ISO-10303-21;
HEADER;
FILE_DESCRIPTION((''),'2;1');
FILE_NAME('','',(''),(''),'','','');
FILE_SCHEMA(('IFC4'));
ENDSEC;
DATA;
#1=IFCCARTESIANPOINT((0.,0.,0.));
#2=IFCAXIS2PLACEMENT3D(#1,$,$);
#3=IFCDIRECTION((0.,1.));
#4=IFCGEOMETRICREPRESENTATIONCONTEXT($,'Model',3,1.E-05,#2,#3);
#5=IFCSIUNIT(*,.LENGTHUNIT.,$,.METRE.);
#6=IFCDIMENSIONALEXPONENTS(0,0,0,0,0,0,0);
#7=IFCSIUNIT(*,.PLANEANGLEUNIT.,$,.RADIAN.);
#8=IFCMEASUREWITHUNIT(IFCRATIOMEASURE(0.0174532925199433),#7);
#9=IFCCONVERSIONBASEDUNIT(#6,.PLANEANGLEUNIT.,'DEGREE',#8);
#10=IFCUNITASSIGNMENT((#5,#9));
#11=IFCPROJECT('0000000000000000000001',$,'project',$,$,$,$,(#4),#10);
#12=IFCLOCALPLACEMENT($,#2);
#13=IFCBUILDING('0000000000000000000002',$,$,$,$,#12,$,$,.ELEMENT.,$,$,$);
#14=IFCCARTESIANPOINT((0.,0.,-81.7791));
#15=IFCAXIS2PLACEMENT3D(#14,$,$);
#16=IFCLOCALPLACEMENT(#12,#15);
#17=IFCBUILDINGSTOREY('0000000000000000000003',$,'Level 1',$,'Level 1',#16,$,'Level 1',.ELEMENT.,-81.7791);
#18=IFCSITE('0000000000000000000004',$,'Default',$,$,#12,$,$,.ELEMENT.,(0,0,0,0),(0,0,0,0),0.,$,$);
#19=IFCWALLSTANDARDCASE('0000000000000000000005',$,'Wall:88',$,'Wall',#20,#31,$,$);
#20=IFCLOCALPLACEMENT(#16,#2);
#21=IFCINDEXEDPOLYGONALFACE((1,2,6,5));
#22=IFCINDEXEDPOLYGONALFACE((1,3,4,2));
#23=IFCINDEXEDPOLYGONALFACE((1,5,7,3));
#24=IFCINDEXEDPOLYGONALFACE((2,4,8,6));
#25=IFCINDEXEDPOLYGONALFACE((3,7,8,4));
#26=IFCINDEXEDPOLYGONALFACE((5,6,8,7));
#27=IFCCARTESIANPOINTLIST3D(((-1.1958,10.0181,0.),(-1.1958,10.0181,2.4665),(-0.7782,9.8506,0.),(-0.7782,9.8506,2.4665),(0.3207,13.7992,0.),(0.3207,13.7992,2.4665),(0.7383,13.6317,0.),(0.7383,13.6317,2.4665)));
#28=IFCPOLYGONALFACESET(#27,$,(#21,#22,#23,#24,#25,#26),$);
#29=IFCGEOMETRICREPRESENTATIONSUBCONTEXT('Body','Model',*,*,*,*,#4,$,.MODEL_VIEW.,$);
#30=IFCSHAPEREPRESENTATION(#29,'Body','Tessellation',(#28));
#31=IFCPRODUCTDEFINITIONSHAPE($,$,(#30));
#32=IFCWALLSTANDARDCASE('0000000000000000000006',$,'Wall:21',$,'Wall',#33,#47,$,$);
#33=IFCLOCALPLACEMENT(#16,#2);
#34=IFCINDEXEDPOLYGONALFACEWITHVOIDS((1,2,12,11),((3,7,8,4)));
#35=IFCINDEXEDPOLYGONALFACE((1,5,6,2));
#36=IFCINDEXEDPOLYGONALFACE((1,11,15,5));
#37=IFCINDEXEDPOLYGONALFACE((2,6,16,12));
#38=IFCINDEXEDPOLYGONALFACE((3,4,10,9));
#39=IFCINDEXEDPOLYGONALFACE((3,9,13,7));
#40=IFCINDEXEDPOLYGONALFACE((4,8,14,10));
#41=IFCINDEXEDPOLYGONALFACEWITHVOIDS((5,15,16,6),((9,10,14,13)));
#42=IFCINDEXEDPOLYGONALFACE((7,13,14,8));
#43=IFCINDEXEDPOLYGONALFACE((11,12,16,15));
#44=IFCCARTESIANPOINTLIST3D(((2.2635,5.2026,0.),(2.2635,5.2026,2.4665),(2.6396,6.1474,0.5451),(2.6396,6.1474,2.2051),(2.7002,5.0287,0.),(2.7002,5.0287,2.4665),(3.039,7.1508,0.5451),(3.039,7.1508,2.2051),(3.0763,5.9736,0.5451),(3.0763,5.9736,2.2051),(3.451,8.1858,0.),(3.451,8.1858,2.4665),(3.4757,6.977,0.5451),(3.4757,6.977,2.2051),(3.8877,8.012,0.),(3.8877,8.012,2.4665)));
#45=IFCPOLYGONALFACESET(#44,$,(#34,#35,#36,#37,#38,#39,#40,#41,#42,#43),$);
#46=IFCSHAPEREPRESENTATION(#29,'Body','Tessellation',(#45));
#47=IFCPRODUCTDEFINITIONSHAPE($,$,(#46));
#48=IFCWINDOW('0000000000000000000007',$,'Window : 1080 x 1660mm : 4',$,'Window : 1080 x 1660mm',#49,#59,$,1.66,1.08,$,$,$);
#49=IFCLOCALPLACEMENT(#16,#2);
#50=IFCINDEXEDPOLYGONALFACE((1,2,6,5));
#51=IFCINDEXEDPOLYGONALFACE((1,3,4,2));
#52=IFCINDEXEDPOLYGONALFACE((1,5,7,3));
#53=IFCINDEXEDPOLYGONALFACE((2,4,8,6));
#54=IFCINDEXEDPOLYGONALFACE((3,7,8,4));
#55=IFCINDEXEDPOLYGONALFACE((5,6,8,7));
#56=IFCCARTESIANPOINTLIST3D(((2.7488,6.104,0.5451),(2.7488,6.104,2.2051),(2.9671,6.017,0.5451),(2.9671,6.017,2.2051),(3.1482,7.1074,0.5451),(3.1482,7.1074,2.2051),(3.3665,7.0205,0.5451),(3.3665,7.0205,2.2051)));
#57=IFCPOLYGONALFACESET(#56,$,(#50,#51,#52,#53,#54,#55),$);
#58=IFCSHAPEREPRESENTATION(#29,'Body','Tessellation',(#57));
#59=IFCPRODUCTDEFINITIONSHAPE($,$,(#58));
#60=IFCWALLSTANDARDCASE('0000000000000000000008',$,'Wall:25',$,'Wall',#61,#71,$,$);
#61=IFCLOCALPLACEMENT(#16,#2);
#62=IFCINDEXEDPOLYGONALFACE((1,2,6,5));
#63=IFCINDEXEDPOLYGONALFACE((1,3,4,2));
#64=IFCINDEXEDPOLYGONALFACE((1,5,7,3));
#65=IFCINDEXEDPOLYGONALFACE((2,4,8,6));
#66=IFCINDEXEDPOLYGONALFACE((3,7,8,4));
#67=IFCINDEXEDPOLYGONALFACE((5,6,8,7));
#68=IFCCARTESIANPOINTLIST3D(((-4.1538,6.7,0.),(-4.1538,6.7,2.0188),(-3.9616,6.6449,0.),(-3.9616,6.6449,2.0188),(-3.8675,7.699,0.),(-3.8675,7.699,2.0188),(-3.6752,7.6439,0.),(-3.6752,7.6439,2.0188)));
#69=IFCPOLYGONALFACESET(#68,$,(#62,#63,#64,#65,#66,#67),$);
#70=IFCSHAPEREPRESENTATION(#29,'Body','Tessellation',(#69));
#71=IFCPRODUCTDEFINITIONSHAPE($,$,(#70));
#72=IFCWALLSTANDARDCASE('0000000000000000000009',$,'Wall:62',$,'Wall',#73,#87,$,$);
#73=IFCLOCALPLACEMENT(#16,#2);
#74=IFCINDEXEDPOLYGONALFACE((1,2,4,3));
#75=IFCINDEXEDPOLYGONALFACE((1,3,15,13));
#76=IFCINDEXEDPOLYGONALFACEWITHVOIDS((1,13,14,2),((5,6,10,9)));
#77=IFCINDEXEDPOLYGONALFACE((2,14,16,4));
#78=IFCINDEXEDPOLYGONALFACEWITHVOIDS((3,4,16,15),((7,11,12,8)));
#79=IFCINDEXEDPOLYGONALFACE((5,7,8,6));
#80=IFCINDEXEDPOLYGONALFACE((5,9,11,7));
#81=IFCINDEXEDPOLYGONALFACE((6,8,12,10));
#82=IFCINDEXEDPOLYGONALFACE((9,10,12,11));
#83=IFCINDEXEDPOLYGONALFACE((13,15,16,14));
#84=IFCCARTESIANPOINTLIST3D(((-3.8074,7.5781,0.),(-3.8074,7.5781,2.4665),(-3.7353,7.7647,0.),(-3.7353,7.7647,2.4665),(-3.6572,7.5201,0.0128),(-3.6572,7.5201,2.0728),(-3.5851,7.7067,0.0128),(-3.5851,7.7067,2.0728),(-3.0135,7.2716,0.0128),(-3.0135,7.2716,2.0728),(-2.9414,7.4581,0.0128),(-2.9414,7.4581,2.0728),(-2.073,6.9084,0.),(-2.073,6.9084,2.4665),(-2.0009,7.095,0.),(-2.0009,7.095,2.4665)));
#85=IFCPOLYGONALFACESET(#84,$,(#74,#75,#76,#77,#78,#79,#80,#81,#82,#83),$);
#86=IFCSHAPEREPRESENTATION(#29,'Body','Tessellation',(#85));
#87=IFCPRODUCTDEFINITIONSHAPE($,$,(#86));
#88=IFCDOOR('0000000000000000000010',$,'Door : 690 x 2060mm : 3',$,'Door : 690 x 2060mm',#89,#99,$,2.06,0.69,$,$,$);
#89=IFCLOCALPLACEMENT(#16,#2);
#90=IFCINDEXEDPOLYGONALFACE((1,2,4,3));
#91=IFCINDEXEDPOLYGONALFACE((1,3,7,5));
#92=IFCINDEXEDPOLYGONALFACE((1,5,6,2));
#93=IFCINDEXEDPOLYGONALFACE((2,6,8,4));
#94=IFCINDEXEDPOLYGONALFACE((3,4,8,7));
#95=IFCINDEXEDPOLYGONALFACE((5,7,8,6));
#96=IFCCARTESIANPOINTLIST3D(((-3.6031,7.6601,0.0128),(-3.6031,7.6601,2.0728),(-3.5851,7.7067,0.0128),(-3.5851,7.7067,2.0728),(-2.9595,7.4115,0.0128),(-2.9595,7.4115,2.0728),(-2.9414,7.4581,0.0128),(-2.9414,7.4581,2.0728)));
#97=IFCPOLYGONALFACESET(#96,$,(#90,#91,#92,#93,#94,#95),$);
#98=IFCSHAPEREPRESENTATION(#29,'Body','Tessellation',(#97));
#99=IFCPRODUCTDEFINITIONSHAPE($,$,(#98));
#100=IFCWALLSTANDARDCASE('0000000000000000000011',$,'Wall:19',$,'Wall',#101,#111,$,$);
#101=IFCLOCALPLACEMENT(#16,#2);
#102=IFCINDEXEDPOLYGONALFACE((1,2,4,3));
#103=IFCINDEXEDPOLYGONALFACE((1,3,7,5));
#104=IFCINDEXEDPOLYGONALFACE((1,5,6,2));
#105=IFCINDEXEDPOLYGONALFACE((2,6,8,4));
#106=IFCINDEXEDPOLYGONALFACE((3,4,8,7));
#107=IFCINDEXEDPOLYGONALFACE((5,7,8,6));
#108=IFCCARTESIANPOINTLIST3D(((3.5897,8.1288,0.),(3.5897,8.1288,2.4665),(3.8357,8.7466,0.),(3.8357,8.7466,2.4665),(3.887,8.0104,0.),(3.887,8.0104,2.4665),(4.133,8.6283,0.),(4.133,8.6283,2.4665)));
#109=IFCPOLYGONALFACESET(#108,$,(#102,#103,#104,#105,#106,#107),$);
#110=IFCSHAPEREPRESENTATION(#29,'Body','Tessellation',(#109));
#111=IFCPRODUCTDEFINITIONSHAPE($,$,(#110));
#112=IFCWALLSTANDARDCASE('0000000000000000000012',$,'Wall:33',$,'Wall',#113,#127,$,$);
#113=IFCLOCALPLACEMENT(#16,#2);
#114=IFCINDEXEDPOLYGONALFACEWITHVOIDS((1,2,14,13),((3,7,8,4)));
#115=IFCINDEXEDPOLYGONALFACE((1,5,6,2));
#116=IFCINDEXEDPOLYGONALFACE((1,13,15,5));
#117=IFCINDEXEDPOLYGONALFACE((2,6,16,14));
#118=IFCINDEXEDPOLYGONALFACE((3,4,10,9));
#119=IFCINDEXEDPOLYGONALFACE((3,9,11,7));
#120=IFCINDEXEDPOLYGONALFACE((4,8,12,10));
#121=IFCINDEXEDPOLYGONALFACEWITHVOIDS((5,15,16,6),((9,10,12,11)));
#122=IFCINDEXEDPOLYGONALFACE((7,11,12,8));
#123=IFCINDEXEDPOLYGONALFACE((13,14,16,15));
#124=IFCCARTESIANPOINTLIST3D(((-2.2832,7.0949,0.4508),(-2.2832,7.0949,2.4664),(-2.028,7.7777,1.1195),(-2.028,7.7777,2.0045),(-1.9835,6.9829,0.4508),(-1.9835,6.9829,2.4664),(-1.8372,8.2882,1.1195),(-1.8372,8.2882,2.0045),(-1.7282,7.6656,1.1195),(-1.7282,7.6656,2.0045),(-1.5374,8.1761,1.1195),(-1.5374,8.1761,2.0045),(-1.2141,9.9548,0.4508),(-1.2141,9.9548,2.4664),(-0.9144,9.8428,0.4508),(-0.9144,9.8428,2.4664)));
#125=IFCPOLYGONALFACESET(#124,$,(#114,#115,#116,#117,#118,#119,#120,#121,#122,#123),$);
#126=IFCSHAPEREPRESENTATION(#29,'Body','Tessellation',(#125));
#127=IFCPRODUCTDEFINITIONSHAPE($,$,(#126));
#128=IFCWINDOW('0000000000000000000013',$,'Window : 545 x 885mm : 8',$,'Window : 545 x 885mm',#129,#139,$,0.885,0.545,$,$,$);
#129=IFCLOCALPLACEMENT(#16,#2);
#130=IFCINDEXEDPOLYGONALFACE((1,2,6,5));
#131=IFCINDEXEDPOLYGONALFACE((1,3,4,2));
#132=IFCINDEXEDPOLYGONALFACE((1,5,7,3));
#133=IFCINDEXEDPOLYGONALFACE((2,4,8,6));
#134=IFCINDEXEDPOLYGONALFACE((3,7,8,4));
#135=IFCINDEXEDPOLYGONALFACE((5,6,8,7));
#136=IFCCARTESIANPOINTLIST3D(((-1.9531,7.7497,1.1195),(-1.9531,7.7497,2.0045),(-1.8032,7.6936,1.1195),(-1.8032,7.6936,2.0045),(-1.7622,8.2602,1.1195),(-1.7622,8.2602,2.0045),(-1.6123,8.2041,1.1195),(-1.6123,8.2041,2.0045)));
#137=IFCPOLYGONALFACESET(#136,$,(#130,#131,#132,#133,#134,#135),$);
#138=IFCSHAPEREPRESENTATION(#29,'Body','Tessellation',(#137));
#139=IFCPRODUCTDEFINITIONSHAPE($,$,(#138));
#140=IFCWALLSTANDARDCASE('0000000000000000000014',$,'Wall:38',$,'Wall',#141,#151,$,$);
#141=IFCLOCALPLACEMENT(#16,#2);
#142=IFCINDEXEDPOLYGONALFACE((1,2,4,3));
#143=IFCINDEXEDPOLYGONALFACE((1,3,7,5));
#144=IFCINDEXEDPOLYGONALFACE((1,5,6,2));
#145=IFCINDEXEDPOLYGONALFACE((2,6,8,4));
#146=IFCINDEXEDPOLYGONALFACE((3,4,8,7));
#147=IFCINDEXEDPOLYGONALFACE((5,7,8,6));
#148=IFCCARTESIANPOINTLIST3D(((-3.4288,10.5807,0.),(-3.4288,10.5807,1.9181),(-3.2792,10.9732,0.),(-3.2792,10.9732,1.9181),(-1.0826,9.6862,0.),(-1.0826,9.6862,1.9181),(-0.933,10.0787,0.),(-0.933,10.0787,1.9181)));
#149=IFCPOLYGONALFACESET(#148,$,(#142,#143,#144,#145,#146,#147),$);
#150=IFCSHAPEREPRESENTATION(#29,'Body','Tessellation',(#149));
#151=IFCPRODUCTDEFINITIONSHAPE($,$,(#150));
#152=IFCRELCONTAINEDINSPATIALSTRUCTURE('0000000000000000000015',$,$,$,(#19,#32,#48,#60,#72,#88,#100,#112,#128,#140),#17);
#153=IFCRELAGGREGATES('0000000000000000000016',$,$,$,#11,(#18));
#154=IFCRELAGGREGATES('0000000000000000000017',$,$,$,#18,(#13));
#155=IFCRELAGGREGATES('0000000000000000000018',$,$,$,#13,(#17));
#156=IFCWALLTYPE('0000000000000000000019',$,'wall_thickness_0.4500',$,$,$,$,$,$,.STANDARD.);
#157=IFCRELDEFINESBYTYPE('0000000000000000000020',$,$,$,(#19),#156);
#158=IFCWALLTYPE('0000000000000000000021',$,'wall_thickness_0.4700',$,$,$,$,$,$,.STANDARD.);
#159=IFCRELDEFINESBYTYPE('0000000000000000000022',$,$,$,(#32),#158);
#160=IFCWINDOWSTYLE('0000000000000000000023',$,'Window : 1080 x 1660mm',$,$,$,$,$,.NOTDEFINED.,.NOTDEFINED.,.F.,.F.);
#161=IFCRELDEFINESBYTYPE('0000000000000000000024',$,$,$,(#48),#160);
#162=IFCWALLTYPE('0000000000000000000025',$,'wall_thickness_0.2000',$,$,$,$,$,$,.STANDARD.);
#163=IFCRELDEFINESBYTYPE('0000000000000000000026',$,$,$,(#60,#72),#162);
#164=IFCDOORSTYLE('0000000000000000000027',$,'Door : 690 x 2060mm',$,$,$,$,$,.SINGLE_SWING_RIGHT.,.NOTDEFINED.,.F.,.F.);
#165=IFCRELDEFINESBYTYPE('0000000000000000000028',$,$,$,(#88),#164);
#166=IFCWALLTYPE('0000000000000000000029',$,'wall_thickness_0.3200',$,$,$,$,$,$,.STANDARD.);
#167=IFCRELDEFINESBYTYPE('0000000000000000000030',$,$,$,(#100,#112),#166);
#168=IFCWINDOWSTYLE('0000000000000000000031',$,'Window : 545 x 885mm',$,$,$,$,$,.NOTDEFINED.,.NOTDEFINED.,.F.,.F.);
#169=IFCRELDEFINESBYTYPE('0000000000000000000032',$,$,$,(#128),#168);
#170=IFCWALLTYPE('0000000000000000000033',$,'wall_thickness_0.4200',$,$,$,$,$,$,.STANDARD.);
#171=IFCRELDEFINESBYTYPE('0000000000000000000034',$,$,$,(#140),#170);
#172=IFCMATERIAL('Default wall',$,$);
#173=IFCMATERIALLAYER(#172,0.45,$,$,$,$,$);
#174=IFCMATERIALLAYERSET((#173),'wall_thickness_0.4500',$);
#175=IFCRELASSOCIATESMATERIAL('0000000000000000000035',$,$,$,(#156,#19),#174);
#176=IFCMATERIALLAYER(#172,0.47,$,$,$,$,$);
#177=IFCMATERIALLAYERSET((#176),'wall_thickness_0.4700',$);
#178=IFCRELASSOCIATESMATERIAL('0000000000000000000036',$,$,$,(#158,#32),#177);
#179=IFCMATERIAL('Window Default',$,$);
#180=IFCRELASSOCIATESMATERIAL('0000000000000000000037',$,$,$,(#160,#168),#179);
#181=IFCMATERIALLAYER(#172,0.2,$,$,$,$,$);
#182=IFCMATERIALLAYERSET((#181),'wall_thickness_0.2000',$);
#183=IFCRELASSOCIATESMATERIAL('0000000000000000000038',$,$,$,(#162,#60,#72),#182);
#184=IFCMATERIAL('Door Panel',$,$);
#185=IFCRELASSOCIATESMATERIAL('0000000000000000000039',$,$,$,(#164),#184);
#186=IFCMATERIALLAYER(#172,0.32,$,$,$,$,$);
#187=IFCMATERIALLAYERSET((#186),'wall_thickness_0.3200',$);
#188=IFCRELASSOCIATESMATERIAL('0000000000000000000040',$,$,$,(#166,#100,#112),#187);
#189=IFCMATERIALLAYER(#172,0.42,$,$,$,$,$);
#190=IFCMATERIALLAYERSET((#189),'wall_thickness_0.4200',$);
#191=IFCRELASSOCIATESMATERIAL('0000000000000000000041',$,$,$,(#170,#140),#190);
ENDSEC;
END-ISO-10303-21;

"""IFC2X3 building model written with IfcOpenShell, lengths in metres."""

from ifc_helpers import new_model, entity, si_unit, converted_unit, direction, frame, frame_2d, origin, origin_2d_with_axis, place, context, subcontext, project, spatial, polyline, rectangle, outline, extrude, source, transform, mapped, material, layer, layer_set, layer_usage, type_object, type_shapes, element, fill, save


model = new_model("IFC2X3")

# Units and contexts
model_context = context("Model", 3, precision=1e-05, world=origin(), true_north=direction((0.0, 1.0)))
body_context = subcontext(model_context, "Body", "Model", "MODEL_VIEW")
ifc_project = project(units=[si_unit("LENGTHUNIT", "METRE"), converted_unit("PLANEANGLEUNIT", "DEGREE", entity("IfcRatioMeasure", 0.0174532925199433), si_unit("PLANEANGLEUNIT", "RADIAN"), dimensions=[0, 0, 0, 0, 0, 0, 0])], contexts=[model_context])

# Site, building, storey
placement_1 = place(None, origin())
site = spatial("IfcSite", under=ifc_project, at=placement_1, Name="Default", CompositionType="ELEMENT", RefLatitude=(0, 0, 0, 0), RefLongitude=(0, 0, 0, 0), RefElevation=0.0)
building = spatial("IfcBuilding", under=site, at=placement_1, CompositionType="ELEMENT")
storey_placement = place(placement_1, frame((0.0, 0.0, -81.7791)))
storey = spatial("IfcBuildingStorey", under=building, at=storey_placement, Name="Level 1", ObjectType="Level 1", LongName="Level 1", CompositionType="ELEMENT", Elevation=-81.7791)

# Shared definitions
ifc_material_1 = material(Name="Default wall")

# Shared definitions
ifc_material_2 = material(Name="Window Default")

# Wall
ifc_layer_1 = layer(ifc_material_1, 0.45)
ifc_layer_set_1 = layer_set([ifc_layer_1], Name="wall_thickness_0.4500")
ifc_layer_usage_1 = layer_usage(ifc_layer_set_1, "AXIS2", "POSITIVE", -0.225)
wall_type_1 = type_object("IfcWallType", Name="wall_thickness_0.4500", PredefinedType="STANDARD", material=ifc_layer_set_1)
wall_1_placement = place(storey_placement, frame((0.5295, 13.7154, 0.0), z_axis=(0.0, 0.0, 1.0), x_axis=(-0.372256, -0.92813, 0.0)))
element("IfcWallStandardCase", 1, at=wall_1_placement, inside=storey, type_object=wall_type_1, material=ifc_layer_usage_1, Name="Wall:88", ObjectType="Wall", context=body_context, shape_type="SweptSolid", body=[
    extrude(outline(polyline([(4.0739, -0.225), (4.0739, 0.225), (0.0, 0.225), (0.0, -0.225), (4.0739, -0.225)])), origin(), (0.0, 0.0, 1.0), 2.4665),
])

# Wall, opening, window
ifc_layer_2 = layer(ifc_material_1, 0.47)
ifc_layer_set_2 = layer_set([ifc_layer_2], Name="wall_thickness_0.4700")
ifc_layer_usage_2 = layer_usage(ifc_layer_set_2, "AXIS2", "POSITIVE", -0.235)
wall_type_2 = type_object("IfcWallType", Name="wall_thickness_0.4700", PredefinedType="STANDARD", material=ifc_layer_set_2)
wall_2_placement = place(storey_placement, frame((3.6693, 8.0989, 0.0), z_axis=(0.0, 0.0, 1.0), x_axis=(-0.36982, -0.929103, 0.0)))
wall_2 = element("IfcWallStandardCase", 2, at=wall_2_placement, inside=storey, type_object=wall_type_2, material=ifc_layer_usage_2, Name="Wall:21", ObjectType="Wall", context=body_context, shape_type="SweptSolid", body=[
    extrude(outline(polyline([(3.2109, -0.235), (3.2109, 0.235), (0.0, 0.235), (0.0, -0.235), (3.2109, -0.235)])), origin(), (0.0, 0.0, 1.0), 2.4665),
])
opening_1_placement = place(wall_2_placement, frame((1.1139, -0.235, 0.5451)))
opening_1 = element("IfcOpeningElement", 3, at=opening_1_placement, cuts=wall_2, ObjectType="Opening", context=body_context, shape_type="SweptSolid", body=[
    extrude(rectangle(XDim=1.08, YDim=1.66, at=frame_2d((0.83, 0.54), x_axis=(0.0, 1.0))), frame((0.0, 0.0, 0.0), z_axis=(0.0, 1.0, 0.0), x_axis=(0.0, 0.0, 1.0)), (0.0, 0.0, 1.0), 0.47),
])
window_style_1 = type_object("IfcWindowStyle", Name="Window : 1080 x 1660mm", ConstructionType="NOTDEFINED", OperationType="NOTDEFINED", ParameterTakesPrecedence=False, Sizeable=False, material=ifc_material_2)
shared_shape_1 = source(origin(), body_context, "Body", "SweptSolid", [
    extrude(rectangle(XDim=0.235, YDim=1.08, at=origin_2d_with_axis()), frame((0.54, 0.235, 0.0), z_axis=(0.0, 0.0, 1.0), x_axis=(0.0, 1.0, 0.0)), (0.0, 0.0, 1.0), 1.66),
])
type_shapes(window_style_1, [shared_shape_1])
window_1_placement = place(opening_1_placement, origin())
window_1 = element("IfcWindow", 4, at=window_1_placement, inside=storey, type_object=window_style_1, Name="Window : 1080 x 1660mm : 4", ObjectType="Window : 1080 x 1660mm", OverallHeight=1.66, OverallWidth=1.08, context=body_context, shape_type="MappedRepresentation", body=[
    mapped(shared_shape_1, transform((0.0, 0.0, 0.0), scale=1.0)),
])
fill(opening_1, window_1)

# Wall
ifc_layer_3 = layer(ifc_material_1, 0.2)
ifc_layer_set_3 = layer_set([ifc_layer_3], Name="wall_thickness_0.2000")
ifc_layer_usage_3 = layer_usage(ifc_layer_set_3, "AXIS2", "POSITIVE", -0.1)
wall_type_3 = type_object("IfcWallType", Name="wall_thickness_0.2000", PredefinedType="STANDARD", material=ifc_layer_set_3)
wall_3_placement = place(storey_placement, frame((-3.7713, 7.6714, 0.0), z_axis=(0.0, 0.0, 1.0), x_axis=(-0.275571, -0.961281, 0.0)))
element("IfcWallStandardCase", 5, at=wall_3_placement, inside=storey, type_object=wall_type_3, material=ifc_layer_usage_3, Name="Wall:25", ObjectType="Wall", context=body_context, shape_type="SweptSolid", body=[
    extrude(outline(polyline([(1.0392, -0.1), (1.0392, 0.1), (0.0, 0.1), (0.0, -0.1), (1.0392, -0.1)])), origin(), (0.0, 0.0, 1.0), 2.0188),
])

# Wall, opening, door
wall_4_placement = place(storey_placement, frame((-3.7713, 7.6714, 0.0), z_axis=(0.0, 0.0, 1.0), x_axis=(0.932862, -0.360233, 0.0)))
wall_4 = element("IfcWallStandardCase", 6, at=wall_4_placement, inside=storey, type_object=wall_type_3, material=ifc_layer_usage_3, Name="Wall:62", ObjectType="Wall", context=body_context, shape_type="SweptSolid", body=[
    extrude(outline(polyline([(1.8592, -0.1), (1.8592, 0.1), (0.0, 0.1), (0.0, -0.1), (1.8592, -0.1)])), origin(), (0.0, 0.0, 1.0), 2.4665),
])
opening_2_placement = place(wall_4_placement, frame((0.161, -0.1, 0.0128)))
opening_2 = element("IfcOpeningElement", 7, at=opening_2_placement, cuts=wall_4, ObjectType="Opening", context=body_context, shape_type="SweptSolid", body=[
    extrude(rectangle(XDim=0.69, YDim=2.06, at=frame_2d((1.03, 0.345), x_axis=(0.0, 1.0))), frame((0.0, 0.0, 0.0), z_axis=(0.0, 1.0, 0.0), x_axis=(0.0, 0.0, 1.0)), (0.0, 0.0, 1.0), 0.2),
])
ifc_material_3 = material(Name="Door Panel")
door_style_1 = type_object("IfcDoorStyle", Name="Door : 690 x 2060mm", ConstructionType="NOTDEFINED", OperationType="SINGLE_SWING_RIGHT", ParameterTakesPrecedence=False, Sizeable=False, material=ifc_material_3)
shared_shape_2 = source(origin(), body_context, "Body", "SweptSolid", [
    extrude(rectangle(XDim=0.05, YDim=0.69, at=origin_2d_with_axis()), frame((0.345, 0.175, 0.0), z_axis=(0.0, 0.0, 1.0), x_axis=(0.0, 1.0, 0.0)), (0.0, 0.0, 1.0), 2.06),
])
type_shapes(door_style_1, [shared_shape_2])
door_1_placement = place(opening_2_placement, origin())
door_1 = element("IfcDoor", 8, at=door_1_placement, inside=storey, type_object=door_style_1, Name="Door : 690 x 2060mm : 3", ObjectType="Door : 690 x 2060mm", OverallHeight=2.06, OverallWidth=0.69, context=body_context, shape_type="MappedRepresentation", body=[
    mapped(shared_shape_2, transform((0.0, 0.0, 0.0), scale=1.0)),
])
fill(opening_2, door_1)

# Wall
ifc_layer_4 = layer(ifc_material_1, 0.32)
ifc_layer_set_4 = layer_set([ifc_layer_4], Name="wall_thickness_0.3200")
ifc_layer_usage_4 = layer_usage(ifc_layer_set_4, "AXIS2", "POSITIVE", -0.16)
wall_type_4 = type_object("IfcWallType", Name="wall_thickness_0.3200", PredefinedType="STANDARD", material=ifc_layer_set_4)
wall_5_placement = place(storey_placement, frame((3.9843, 8.6874, 0.0), z_axis=(0.0, 0.0, 1.0), x_axis=(-0.369819, -0.929104, 0.0)))
element("IfcWallStandardCase", 9, at=wall_5_placement, inside=storey, type_object=wall_type_4, material=ifc_layer_usage_4, Name="Wall:19", ObjectType="Wall", context=body_context, shape_type="SweptSolid", body=[
    extrude(outline(polyline([(0.665, -0.16), (0.665, 0.16), (0.0, 0.16), (0.0, -0.16), (0.665, -0.16)])), origin(), (0.0, 0.0, 1.0), 2.4665),
])

# Wall, opening, window
placement_2 = place(placement_1, frame((0.0, 0.0, -81.3283)))
wall_6_placement = place(placement_2, frame((-1.0643, 9.8988, 0.0), z_axis=(0.0, 0.0, 1.0), x_axis=(-0.350153, -0.936692, 0.0)))
wall_6 = element("IfcWallStandardCase", 10, at=wall_6_placement, inside=storey, type_object=wall_type_4, material=ifc_layer_usage_4, Name="Wall:33", ObjectType="Wall", context=body_context, shape_type="SweptSolid", body=[
    extrude(outline(polyline([(3.0532, -0.16), (3.0532, 0.16), (0.0, 0.16), (0.0, -0.16), (3.0532, -0.16)])), origin(), (0.0, 0.0, 1.0), 2.0157),
])
opening_3_placement = place(wall_6_placement, frame((1.7793, -0.16, 0.6687)))
opening_3 = element("IfcOpeningElement", 11, at=opening_3_placement, cuts=wall_6, ObjectType="Opening", context=body_context, shape_type="SweptSolid", body=[
    extrude(rectangle(XDim=0.545, YDim=0.885, at=frame_2d((0.4425, 0.2725), x_axis=(0.0, 1.0))), frame((0.0, 0.0, 0.0), z_axis=(0.0, 1.0, 0.0), x_axis=(0.0, 0.0, 1.0)), (0.0, 0.0, 1.0), 0.32),
])
window_style_2 = type_object("IfcWindowStyle", Name="Window : 545 x 885mm", ConstructionType="NOTDEFINED", OperationType="NOTDEFINED", ParameterTakesPrecedence=False, Sizeable=False, material=ifc_material_2)
shared_shape_3 = source(origin(), body_context, "Body", "SweptSolid", [
    extrude(rectangle(XDim=0.16, YDim=0.545, at=origin_2d_with_axis()), frame((0.2725, 0.16, 0.0), z_axis=(0.0, 0.0, 1.0), x_axis=(0.0, 1.0, 0.0)), (0.0, 0.0, 1.0), 0.885),
])
type_shapes(window_style_2, [shared_shape_3])
window_2_placement = place(opening_3_placement, origin())
window_2 = element("IfcWindow", 12, at=window_2_placement, inside=storey, type_object=window_style_2, Name="Window : 545 x 885mm : 8", ObjectType="Window : 545 x 885mm", OverallHeight=0.885, OverallWidth=0.545, context=body_context, shape_type="MappedRepresentation", body=[
    mapped(shared_shape_3, transform((0.0, 0.0, 0.0), scale=1.0)),
])
fill(opening_3, window_2)

# Wall
ifc_layer_5 = layer(ifc_material_1, 0.42)
ifc_layer_set_5 = layer_set([ifc_layer_5], Name="wall_thickness_0.4200")
ifc_layer_usage_5 = layer_usage(ifc_layer_set_5, "AXIS2", "POSITIVE", -0.21)
wall_type_5 = type_object("IfcWallType", Name="wall_thickness_0.4200", PredefinedType="STANDARD", material=ifc_layer_set_5)
wall_7_placement = place(storey_placement, frame((-3.354, 10.7769, 0.0), z_axis=(0.0, 0.0, 1.0), x_axis=(0.934395, -0.356239, 0.0)))
element("IfcWallStandardCase", 13, at=wall_7_placement, inside=storey, type_object=wall_type_5, material=ifc_layer_usage_5, Name="Wall:38", ObjectType="Wall", context=body_context, shape_type="SweptSolid", body=[
    extrude(outline(polyline([(2.5109, -0.21), (2.5109, 0.21), (0.0, 0.21), (0.0, -0.21), (2.5109, -0.21)])), origin(), (0.0, 0.0, 1.0), 1.9181),
])

save(model, "model.ifc")
